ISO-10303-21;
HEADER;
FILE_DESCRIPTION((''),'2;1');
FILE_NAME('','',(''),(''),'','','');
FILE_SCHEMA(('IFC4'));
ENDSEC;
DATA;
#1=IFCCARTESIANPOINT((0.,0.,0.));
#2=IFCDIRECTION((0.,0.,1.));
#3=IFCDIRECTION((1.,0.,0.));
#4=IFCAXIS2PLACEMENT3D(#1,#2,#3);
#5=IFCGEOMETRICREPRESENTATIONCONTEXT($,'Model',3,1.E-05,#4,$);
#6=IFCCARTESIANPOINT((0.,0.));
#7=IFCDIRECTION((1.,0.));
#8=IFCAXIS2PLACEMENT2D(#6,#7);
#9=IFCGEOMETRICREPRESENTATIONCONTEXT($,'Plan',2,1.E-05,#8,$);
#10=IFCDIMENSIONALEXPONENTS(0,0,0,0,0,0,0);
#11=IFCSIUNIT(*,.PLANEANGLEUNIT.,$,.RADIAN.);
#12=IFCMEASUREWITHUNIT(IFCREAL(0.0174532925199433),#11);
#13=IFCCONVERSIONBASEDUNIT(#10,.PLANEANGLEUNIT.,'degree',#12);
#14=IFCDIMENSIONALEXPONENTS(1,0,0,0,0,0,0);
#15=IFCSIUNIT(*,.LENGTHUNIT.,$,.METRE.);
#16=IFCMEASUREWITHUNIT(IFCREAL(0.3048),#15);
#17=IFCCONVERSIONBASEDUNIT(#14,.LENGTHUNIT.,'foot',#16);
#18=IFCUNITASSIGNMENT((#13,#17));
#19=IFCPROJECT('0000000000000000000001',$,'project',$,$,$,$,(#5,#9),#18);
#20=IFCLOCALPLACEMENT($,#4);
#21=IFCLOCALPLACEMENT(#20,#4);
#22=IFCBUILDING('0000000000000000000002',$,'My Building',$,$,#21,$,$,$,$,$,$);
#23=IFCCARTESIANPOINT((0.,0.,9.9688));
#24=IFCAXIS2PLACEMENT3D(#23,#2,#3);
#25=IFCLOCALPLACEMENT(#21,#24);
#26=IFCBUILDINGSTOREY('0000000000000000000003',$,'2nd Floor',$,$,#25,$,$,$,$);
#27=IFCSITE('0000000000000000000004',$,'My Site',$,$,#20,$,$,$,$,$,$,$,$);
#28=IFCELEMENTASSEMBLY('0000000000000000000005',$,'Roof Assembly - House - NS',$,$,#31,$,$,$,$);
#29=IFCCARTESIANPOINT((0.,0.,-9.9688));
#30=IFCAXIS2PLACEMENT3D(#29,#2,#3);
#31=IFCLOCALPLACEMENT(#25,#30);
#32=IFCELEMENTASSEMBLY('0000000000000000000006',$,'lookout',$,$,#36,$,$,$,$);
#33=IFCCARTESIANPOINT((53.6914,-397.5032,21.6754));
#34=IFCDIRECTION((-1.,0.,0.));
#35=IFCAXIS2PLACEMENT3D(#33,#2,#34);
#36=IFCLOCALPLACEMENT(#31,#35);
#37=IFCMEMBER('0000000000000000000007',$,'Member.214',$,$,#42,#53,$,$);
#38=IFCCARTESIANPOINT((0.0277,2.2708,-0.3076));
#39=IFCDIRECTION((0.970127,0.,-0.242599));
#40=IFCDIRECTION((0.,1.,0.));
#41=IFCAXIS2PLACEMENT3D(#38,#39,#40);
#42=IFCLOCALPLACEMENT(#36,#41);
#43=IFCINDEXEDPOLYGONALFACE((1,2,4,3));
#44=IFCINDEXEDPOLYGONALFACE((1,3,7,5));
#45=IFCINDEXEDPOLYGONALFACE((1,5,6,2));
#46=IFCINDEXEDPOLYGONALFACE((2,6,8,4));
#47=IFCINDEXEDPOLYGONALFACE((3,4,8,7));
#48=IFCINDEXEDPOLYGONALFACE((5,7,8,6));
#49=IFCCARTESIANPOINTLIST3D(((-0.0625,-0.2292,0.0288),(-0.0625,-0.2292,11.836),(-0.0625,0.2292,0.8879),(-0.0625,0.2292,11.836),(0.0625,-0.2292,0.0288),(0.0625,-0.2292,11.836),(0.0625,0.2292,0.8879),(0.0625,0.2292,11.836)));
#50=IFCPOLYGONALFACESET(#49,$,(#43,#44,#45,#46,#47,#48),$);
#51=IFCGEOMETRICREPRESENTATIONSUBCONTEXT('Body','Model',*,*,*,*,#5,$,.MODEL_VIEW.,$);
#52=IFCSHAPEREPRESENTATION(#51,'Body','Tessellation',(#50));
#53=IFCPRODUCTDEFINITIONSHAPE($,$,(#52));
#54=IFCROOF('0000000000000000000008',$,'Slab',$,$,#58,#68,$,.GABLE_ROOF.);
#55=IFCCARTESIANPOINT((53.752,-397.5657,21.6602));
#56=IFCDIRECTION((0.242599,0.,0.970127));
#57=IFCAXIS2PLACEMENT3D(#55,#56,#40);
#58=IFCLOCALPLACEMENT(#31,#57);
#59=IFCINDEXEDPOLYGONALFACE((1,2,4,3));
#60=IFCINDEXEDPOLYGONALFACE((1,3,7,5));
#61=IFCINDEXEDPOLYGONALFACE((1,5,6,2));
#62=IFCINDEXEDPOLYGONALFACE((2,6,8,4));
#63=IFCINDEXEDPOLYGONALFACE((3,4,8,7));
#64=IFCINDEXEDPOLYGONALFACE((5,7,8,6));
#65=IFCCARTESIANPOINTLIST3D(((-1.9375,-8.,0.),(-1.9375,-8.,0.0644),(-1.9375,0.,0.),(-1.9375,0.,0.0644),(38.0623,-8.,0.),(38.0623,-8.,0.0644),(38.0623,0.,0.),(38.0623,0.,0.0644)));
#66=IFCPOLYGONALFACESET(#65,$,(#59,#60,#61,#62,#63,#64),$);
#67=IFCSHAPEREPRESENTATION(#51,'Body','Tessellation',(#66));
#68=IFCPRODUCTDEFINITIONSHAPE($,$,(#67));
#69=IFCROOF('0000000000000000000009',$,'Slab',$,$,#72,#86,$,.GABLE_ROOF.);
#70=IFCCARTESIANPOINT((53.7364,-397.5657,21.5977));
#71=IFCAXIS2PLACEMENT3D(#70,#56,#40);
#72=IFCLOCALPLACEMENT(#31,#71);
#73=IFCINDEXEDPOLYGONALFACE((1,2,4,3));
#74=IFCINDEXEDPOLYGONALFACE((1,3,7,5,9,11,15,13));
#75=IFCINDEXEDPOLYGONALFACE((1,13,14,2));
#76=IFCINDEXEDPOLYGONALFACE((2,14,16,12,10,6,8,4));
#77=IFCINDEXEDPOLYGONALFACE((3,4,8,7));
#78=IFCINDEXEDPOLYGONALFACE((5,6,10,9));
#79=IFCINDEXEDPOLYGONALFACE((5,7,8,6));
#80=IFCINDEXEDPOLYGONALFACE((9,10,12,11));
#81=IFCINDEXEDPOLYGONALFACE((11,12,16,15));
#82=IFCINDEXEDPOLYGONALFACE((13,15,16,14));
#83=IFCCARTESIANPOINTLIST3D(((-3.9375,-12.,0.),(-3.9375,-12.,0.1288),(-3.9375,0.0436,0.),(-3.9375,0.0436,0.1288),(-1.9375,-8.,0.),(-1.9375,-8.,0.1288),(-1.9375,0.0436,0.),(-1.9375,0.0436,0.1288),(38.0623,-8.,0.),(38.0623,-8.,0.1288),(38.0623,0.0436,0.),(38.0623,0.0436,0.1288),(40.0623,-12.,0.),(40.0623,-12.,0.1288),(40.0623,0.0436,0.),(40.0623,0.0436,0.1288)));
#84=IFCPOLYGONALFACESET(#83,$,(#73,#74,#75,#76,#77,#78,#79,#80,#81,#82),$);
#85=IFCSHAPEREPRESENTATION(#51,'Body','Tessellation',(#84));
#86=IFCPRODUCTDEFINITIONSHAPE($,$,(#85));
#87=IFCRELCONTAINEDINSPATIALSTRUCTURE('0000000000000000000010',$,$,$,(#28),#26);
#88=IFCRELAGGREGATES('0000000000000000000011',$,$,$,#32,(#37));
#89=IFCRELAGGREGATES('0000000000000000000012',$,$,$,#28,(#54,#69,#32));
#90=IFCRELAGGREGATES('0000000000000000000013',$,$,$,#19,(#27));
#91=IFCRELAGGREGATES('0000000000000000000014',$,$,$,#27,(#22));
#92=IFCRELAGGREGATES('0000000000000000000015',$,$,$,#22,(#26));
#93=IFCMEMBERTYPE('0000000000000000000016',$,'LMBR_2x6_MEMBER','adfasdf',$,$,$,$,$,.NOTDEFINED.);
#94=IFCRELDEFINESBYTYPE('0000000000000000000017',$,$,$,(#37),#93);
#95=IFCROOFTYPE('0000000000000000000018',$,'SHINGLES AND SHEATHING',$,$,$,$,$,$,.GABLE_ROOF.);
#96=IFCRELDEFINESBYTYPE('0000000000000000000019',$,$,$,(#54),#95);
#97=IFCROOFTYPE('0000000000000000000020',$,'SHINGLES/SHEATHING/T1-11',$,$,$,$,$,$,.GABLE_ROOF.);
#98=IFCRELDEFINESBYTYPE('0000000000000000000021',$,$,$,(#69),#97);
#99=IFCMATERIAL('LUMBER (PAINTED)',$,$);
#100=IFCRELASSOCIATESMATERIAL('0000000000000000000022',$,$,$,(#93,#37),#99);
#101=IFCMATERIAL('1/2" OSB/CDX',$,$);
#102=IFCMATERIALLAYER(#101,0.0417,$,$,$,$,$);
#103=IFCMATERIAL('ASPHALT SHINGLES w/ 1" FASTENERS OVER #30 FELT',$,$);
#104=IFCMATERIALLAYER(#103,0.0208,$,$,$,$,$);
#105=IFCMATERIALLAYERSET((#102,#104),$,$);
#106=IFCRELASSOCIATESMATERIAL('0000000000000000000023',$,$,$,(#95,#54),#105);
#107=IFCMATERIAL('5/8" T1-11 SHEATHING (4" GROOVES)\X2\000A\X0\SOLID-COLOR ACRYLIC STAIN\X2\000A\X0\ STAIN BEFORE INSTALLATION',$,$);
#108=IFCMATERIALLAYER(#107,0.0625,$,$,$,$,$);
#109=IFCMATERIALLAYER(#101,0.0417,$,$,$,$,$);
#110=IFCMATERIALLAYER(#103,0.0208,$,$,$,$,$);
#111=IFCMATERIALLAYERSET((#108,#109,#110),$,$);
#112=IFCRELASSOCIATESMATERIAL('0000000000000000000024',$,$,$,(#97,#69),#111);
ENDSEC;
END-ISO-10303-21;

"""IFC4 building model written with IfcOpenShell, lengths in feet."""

from ifc_helpers import new_model, entity, si_unit, converted_unit, frame, origin_with_axes, origin_2d_with_axis, place, context, subcontext, project, spatial, indexed_curve, outline, extrude, clip, halfspace, material, layer, layer_set, layer_usage, material_profile, profile_set, profile_usage, type_object, element, aggregate, save


model = new_model("IFC4")

# Units and contexts
model_context = context("Model", 3, precision=1e-05, world=origin_with_axes())
plan_context = context("Plan", 2, precision=1e-05, world=origin_2d_with_axis())
body_context = subcontext(model_context, "Body", "Model", "MODEL_VIEW")
ifc_project = project(units=[converted_unit("PLANEANGLEUNIT", "degree", entity("IfcReal", 0.0174532925199433), si_unit("PLANEANGLEUNIT", "RADIAN"), dimensions=[0, 0, 0, 0, 0, 0, 0]), converted_unit("LENGTHUNIT", "foot", entity("IfcReal", 0.3048), si_unit("LENGTHUNIT", "METRE"), dimensions=[1, 0, 0, 0, 0, 0, 0])], contexts=[model_context, plan_context])

# Site, building, storey
site_placement = place(None, origin_with_axes())
site = spatial("IfcSite", under=ifc_project, at=site_placement, Name="My Site")
building_placement = place(site_placement, origin_with_axes())
building = spatial("IfcBuilding", under=site, at=building_placement, Name="My Building")
storey_placement = place(building_placement, frame((0.0, 0.0, 9.9688), z_axis=(0.0, 0.0, 1.0), x_axis=(1.0, 0.0, 0.0)))
storey = spatial("IfcBuildingStorey", under=building, at=storey_placement, Name="2nd Floor")

# Element assemblies, member, roofs
assembly_1_placement = place(storey_placement, frame((0.0, 0.0, -9.9688), z_axis=(0.0, 0.0, 1.0), x_axis=(1.0, 0.0, 0.0)))
assembly_1 = element("IfcElementAssembly", 1, at=assembly_1_placement, inside=storey, Name="Roof Assembly - House - NS")
ifc_material_1 = material(Name="LUMBER (PAINTED)")
assembly_2_placement = place(assembly_1_placement, frame((53.6914, -397.5032, 21.6754), z_axis=(0.0, 0.0, 1.0), x_axis=(-1.0, 0.0, 0.0)))
assembly_2 = element("IfcElementAssembly", 2, at=assembly_2_placement, Name="lookout")
ifc_material_profile_1 = material_profile(ifc_material_1, outline(indexed_curve([(-0.0625, 0.2292), (0.0625, 0.2292), (0.0625, -0.2292), (-0.0625, -0.2292), (-0.0625, 0.2292)])))
ifc_profile_set_1 = profile_set([ifc_material_profile_1])
ifc_profile_usage_1 = profile_usage(ifc_profile_set_1)
member_type_1 = type_object("IfcMemberType", Name="LMBR_2x6_MEMBER", Description="adfasdf", PredefinedType="NOTDEFINED", material=ifc_profile_set_1)
member_1_placement = place(assembly_2_placement, frame((0.0277, 2.2708, -0.3076), z_axis=(0.970127, 0.0, -0.242599), x_axis=(0.0, 1.0, 0.0)))
member_1 = element("IfcMember", 3, at=member_1_placement, type_object=member_type_1, material=ifc_profile_usage_1, Name="Member.214", context=body_context, shape_type="Clipping", body=[
    clip(extrude(outline(indexed_curve([(-0.0625, 0.2292), (0.0625, 0.2292), (0.0625, -0.2292), (-0.0625, -0.2292), (-0.0625, 0.2292)])), origin_with_axes(), (0.0, 0.0, 1.0), 11.836), halfspace(frame((0.0, 0.2427, 0.9133), z_axis=(0.0, 0.882291, -0.470704), x_axis=(1.0, 0.0, 0.0)), False)),
])
aggregate(assembly_2, [member_1])
ifc_material_2 = material(Name="1/2\" OSB/CDX")
ifc_layer_1 = layer(ifc_material_2, 0.0417)
ifc_material_3 = material(Name="ASPHALT SHINGLES w/ 1\" FASTENERS OVER #30 FELT")
ifc_layer_2 = layer(ifc_material_3, 0.0208)
ifc_layer_set_1 = layer_set([ifc_layer_1, ifc_layer_2])
ifc_layer_usage_1 = layer_usage(ifc_layer_set_1, "AXIS3", "POSITIVE", 0.0)
roof_type_1 = type_object("IfcRoofType", Name="SHINGLES AND SHEATHING", PredefinedType="GABLE_ROOF", material=ifc_layer_set_1)
roof_1_placement = place(assembly_1_placement, frame((53.752, -397.5657, 21.6602), z_axis=(0.242599, 0.0, 0.970127), x_axis=(0.0, 1.0, 0.0)))
roof_1 = element("IfcRoof", 4, at=roof_1_placement, type_object=roof_type_1, material=ifc_layer_usage_1, Name="Slab", PredefinedType="GABLE_ROOF", context=body_context, shape_type="SweptSolid", body=[
    extrude(outline(indexed_curve([(38.0623, 0.0), (38.0623, -8.0), (-1.9375, -8.0), (-1.9375, 0.0), (38.0623, 0.0)])), None, (0.0, 0.0, 1.0), 0.0644),
])
ifc_material_4 = material(Name="5/8\" T1-11 SHEATHING (4\" GROOVES)\nSOLID-COLOR ACRYLIC STAIN\n STAIN BEFORE INSTALLATION")
ifc_layer_3 = layer(ifc_material_4, 0.0625)
ifc_layer_4 = layer(ifc_material_2, 0.0417)
ifc_layer_5 = layer(ifc_material_3, 0.0208)
ifc_layer_set_2 = layer_set([ifc_layer_3, ifc_layer_4, ifc_layer_5])
ifc_layer_usage_2 = layer_usage(ifc_layer_set_2, "AXIS3", "POSITIVE", 0.0)
roof_type_2 = type_object("IfcRoofType", Name="SHINGLES/SHEATHING/T1-11", PredefinedType="GABLE_ROOF", material=ifc_layer_set_2)
roof_2_placement = place(assembly_1_placement, frame((53.7364, -397.5657, 21.5977), z_axis=(0.242599, 0.0, 0.970127), x_axis=(0.0, 1.0, 0.0)))
roof_2 = element("IfcRoof", 5, at=roof_2_placement, type_object=roof_type_2, material=ifc_layer_usage_2, Name="Slab", PredefinedType="GABLE_ROOF", context=body_context, shape_type="SweptSolid", body=[
    extrude(outline(indexed_curve([(40.0623, -12.0), (-3.9375, -12.0), (-3.9375, 0.0436), (-1.9375, 0.0436), (-1.9375, -8.0), (38.0623, -8.0), (38.0623, 0.0436), (40.0623, 0.0436), (40.0623, -12.0)])), None, (0.0, 0.0, 1.0), 0.1288),
])
aggregate(assembly_1, [roof_1, roof_2, assembly_2])

save(model, "model.ifc")
